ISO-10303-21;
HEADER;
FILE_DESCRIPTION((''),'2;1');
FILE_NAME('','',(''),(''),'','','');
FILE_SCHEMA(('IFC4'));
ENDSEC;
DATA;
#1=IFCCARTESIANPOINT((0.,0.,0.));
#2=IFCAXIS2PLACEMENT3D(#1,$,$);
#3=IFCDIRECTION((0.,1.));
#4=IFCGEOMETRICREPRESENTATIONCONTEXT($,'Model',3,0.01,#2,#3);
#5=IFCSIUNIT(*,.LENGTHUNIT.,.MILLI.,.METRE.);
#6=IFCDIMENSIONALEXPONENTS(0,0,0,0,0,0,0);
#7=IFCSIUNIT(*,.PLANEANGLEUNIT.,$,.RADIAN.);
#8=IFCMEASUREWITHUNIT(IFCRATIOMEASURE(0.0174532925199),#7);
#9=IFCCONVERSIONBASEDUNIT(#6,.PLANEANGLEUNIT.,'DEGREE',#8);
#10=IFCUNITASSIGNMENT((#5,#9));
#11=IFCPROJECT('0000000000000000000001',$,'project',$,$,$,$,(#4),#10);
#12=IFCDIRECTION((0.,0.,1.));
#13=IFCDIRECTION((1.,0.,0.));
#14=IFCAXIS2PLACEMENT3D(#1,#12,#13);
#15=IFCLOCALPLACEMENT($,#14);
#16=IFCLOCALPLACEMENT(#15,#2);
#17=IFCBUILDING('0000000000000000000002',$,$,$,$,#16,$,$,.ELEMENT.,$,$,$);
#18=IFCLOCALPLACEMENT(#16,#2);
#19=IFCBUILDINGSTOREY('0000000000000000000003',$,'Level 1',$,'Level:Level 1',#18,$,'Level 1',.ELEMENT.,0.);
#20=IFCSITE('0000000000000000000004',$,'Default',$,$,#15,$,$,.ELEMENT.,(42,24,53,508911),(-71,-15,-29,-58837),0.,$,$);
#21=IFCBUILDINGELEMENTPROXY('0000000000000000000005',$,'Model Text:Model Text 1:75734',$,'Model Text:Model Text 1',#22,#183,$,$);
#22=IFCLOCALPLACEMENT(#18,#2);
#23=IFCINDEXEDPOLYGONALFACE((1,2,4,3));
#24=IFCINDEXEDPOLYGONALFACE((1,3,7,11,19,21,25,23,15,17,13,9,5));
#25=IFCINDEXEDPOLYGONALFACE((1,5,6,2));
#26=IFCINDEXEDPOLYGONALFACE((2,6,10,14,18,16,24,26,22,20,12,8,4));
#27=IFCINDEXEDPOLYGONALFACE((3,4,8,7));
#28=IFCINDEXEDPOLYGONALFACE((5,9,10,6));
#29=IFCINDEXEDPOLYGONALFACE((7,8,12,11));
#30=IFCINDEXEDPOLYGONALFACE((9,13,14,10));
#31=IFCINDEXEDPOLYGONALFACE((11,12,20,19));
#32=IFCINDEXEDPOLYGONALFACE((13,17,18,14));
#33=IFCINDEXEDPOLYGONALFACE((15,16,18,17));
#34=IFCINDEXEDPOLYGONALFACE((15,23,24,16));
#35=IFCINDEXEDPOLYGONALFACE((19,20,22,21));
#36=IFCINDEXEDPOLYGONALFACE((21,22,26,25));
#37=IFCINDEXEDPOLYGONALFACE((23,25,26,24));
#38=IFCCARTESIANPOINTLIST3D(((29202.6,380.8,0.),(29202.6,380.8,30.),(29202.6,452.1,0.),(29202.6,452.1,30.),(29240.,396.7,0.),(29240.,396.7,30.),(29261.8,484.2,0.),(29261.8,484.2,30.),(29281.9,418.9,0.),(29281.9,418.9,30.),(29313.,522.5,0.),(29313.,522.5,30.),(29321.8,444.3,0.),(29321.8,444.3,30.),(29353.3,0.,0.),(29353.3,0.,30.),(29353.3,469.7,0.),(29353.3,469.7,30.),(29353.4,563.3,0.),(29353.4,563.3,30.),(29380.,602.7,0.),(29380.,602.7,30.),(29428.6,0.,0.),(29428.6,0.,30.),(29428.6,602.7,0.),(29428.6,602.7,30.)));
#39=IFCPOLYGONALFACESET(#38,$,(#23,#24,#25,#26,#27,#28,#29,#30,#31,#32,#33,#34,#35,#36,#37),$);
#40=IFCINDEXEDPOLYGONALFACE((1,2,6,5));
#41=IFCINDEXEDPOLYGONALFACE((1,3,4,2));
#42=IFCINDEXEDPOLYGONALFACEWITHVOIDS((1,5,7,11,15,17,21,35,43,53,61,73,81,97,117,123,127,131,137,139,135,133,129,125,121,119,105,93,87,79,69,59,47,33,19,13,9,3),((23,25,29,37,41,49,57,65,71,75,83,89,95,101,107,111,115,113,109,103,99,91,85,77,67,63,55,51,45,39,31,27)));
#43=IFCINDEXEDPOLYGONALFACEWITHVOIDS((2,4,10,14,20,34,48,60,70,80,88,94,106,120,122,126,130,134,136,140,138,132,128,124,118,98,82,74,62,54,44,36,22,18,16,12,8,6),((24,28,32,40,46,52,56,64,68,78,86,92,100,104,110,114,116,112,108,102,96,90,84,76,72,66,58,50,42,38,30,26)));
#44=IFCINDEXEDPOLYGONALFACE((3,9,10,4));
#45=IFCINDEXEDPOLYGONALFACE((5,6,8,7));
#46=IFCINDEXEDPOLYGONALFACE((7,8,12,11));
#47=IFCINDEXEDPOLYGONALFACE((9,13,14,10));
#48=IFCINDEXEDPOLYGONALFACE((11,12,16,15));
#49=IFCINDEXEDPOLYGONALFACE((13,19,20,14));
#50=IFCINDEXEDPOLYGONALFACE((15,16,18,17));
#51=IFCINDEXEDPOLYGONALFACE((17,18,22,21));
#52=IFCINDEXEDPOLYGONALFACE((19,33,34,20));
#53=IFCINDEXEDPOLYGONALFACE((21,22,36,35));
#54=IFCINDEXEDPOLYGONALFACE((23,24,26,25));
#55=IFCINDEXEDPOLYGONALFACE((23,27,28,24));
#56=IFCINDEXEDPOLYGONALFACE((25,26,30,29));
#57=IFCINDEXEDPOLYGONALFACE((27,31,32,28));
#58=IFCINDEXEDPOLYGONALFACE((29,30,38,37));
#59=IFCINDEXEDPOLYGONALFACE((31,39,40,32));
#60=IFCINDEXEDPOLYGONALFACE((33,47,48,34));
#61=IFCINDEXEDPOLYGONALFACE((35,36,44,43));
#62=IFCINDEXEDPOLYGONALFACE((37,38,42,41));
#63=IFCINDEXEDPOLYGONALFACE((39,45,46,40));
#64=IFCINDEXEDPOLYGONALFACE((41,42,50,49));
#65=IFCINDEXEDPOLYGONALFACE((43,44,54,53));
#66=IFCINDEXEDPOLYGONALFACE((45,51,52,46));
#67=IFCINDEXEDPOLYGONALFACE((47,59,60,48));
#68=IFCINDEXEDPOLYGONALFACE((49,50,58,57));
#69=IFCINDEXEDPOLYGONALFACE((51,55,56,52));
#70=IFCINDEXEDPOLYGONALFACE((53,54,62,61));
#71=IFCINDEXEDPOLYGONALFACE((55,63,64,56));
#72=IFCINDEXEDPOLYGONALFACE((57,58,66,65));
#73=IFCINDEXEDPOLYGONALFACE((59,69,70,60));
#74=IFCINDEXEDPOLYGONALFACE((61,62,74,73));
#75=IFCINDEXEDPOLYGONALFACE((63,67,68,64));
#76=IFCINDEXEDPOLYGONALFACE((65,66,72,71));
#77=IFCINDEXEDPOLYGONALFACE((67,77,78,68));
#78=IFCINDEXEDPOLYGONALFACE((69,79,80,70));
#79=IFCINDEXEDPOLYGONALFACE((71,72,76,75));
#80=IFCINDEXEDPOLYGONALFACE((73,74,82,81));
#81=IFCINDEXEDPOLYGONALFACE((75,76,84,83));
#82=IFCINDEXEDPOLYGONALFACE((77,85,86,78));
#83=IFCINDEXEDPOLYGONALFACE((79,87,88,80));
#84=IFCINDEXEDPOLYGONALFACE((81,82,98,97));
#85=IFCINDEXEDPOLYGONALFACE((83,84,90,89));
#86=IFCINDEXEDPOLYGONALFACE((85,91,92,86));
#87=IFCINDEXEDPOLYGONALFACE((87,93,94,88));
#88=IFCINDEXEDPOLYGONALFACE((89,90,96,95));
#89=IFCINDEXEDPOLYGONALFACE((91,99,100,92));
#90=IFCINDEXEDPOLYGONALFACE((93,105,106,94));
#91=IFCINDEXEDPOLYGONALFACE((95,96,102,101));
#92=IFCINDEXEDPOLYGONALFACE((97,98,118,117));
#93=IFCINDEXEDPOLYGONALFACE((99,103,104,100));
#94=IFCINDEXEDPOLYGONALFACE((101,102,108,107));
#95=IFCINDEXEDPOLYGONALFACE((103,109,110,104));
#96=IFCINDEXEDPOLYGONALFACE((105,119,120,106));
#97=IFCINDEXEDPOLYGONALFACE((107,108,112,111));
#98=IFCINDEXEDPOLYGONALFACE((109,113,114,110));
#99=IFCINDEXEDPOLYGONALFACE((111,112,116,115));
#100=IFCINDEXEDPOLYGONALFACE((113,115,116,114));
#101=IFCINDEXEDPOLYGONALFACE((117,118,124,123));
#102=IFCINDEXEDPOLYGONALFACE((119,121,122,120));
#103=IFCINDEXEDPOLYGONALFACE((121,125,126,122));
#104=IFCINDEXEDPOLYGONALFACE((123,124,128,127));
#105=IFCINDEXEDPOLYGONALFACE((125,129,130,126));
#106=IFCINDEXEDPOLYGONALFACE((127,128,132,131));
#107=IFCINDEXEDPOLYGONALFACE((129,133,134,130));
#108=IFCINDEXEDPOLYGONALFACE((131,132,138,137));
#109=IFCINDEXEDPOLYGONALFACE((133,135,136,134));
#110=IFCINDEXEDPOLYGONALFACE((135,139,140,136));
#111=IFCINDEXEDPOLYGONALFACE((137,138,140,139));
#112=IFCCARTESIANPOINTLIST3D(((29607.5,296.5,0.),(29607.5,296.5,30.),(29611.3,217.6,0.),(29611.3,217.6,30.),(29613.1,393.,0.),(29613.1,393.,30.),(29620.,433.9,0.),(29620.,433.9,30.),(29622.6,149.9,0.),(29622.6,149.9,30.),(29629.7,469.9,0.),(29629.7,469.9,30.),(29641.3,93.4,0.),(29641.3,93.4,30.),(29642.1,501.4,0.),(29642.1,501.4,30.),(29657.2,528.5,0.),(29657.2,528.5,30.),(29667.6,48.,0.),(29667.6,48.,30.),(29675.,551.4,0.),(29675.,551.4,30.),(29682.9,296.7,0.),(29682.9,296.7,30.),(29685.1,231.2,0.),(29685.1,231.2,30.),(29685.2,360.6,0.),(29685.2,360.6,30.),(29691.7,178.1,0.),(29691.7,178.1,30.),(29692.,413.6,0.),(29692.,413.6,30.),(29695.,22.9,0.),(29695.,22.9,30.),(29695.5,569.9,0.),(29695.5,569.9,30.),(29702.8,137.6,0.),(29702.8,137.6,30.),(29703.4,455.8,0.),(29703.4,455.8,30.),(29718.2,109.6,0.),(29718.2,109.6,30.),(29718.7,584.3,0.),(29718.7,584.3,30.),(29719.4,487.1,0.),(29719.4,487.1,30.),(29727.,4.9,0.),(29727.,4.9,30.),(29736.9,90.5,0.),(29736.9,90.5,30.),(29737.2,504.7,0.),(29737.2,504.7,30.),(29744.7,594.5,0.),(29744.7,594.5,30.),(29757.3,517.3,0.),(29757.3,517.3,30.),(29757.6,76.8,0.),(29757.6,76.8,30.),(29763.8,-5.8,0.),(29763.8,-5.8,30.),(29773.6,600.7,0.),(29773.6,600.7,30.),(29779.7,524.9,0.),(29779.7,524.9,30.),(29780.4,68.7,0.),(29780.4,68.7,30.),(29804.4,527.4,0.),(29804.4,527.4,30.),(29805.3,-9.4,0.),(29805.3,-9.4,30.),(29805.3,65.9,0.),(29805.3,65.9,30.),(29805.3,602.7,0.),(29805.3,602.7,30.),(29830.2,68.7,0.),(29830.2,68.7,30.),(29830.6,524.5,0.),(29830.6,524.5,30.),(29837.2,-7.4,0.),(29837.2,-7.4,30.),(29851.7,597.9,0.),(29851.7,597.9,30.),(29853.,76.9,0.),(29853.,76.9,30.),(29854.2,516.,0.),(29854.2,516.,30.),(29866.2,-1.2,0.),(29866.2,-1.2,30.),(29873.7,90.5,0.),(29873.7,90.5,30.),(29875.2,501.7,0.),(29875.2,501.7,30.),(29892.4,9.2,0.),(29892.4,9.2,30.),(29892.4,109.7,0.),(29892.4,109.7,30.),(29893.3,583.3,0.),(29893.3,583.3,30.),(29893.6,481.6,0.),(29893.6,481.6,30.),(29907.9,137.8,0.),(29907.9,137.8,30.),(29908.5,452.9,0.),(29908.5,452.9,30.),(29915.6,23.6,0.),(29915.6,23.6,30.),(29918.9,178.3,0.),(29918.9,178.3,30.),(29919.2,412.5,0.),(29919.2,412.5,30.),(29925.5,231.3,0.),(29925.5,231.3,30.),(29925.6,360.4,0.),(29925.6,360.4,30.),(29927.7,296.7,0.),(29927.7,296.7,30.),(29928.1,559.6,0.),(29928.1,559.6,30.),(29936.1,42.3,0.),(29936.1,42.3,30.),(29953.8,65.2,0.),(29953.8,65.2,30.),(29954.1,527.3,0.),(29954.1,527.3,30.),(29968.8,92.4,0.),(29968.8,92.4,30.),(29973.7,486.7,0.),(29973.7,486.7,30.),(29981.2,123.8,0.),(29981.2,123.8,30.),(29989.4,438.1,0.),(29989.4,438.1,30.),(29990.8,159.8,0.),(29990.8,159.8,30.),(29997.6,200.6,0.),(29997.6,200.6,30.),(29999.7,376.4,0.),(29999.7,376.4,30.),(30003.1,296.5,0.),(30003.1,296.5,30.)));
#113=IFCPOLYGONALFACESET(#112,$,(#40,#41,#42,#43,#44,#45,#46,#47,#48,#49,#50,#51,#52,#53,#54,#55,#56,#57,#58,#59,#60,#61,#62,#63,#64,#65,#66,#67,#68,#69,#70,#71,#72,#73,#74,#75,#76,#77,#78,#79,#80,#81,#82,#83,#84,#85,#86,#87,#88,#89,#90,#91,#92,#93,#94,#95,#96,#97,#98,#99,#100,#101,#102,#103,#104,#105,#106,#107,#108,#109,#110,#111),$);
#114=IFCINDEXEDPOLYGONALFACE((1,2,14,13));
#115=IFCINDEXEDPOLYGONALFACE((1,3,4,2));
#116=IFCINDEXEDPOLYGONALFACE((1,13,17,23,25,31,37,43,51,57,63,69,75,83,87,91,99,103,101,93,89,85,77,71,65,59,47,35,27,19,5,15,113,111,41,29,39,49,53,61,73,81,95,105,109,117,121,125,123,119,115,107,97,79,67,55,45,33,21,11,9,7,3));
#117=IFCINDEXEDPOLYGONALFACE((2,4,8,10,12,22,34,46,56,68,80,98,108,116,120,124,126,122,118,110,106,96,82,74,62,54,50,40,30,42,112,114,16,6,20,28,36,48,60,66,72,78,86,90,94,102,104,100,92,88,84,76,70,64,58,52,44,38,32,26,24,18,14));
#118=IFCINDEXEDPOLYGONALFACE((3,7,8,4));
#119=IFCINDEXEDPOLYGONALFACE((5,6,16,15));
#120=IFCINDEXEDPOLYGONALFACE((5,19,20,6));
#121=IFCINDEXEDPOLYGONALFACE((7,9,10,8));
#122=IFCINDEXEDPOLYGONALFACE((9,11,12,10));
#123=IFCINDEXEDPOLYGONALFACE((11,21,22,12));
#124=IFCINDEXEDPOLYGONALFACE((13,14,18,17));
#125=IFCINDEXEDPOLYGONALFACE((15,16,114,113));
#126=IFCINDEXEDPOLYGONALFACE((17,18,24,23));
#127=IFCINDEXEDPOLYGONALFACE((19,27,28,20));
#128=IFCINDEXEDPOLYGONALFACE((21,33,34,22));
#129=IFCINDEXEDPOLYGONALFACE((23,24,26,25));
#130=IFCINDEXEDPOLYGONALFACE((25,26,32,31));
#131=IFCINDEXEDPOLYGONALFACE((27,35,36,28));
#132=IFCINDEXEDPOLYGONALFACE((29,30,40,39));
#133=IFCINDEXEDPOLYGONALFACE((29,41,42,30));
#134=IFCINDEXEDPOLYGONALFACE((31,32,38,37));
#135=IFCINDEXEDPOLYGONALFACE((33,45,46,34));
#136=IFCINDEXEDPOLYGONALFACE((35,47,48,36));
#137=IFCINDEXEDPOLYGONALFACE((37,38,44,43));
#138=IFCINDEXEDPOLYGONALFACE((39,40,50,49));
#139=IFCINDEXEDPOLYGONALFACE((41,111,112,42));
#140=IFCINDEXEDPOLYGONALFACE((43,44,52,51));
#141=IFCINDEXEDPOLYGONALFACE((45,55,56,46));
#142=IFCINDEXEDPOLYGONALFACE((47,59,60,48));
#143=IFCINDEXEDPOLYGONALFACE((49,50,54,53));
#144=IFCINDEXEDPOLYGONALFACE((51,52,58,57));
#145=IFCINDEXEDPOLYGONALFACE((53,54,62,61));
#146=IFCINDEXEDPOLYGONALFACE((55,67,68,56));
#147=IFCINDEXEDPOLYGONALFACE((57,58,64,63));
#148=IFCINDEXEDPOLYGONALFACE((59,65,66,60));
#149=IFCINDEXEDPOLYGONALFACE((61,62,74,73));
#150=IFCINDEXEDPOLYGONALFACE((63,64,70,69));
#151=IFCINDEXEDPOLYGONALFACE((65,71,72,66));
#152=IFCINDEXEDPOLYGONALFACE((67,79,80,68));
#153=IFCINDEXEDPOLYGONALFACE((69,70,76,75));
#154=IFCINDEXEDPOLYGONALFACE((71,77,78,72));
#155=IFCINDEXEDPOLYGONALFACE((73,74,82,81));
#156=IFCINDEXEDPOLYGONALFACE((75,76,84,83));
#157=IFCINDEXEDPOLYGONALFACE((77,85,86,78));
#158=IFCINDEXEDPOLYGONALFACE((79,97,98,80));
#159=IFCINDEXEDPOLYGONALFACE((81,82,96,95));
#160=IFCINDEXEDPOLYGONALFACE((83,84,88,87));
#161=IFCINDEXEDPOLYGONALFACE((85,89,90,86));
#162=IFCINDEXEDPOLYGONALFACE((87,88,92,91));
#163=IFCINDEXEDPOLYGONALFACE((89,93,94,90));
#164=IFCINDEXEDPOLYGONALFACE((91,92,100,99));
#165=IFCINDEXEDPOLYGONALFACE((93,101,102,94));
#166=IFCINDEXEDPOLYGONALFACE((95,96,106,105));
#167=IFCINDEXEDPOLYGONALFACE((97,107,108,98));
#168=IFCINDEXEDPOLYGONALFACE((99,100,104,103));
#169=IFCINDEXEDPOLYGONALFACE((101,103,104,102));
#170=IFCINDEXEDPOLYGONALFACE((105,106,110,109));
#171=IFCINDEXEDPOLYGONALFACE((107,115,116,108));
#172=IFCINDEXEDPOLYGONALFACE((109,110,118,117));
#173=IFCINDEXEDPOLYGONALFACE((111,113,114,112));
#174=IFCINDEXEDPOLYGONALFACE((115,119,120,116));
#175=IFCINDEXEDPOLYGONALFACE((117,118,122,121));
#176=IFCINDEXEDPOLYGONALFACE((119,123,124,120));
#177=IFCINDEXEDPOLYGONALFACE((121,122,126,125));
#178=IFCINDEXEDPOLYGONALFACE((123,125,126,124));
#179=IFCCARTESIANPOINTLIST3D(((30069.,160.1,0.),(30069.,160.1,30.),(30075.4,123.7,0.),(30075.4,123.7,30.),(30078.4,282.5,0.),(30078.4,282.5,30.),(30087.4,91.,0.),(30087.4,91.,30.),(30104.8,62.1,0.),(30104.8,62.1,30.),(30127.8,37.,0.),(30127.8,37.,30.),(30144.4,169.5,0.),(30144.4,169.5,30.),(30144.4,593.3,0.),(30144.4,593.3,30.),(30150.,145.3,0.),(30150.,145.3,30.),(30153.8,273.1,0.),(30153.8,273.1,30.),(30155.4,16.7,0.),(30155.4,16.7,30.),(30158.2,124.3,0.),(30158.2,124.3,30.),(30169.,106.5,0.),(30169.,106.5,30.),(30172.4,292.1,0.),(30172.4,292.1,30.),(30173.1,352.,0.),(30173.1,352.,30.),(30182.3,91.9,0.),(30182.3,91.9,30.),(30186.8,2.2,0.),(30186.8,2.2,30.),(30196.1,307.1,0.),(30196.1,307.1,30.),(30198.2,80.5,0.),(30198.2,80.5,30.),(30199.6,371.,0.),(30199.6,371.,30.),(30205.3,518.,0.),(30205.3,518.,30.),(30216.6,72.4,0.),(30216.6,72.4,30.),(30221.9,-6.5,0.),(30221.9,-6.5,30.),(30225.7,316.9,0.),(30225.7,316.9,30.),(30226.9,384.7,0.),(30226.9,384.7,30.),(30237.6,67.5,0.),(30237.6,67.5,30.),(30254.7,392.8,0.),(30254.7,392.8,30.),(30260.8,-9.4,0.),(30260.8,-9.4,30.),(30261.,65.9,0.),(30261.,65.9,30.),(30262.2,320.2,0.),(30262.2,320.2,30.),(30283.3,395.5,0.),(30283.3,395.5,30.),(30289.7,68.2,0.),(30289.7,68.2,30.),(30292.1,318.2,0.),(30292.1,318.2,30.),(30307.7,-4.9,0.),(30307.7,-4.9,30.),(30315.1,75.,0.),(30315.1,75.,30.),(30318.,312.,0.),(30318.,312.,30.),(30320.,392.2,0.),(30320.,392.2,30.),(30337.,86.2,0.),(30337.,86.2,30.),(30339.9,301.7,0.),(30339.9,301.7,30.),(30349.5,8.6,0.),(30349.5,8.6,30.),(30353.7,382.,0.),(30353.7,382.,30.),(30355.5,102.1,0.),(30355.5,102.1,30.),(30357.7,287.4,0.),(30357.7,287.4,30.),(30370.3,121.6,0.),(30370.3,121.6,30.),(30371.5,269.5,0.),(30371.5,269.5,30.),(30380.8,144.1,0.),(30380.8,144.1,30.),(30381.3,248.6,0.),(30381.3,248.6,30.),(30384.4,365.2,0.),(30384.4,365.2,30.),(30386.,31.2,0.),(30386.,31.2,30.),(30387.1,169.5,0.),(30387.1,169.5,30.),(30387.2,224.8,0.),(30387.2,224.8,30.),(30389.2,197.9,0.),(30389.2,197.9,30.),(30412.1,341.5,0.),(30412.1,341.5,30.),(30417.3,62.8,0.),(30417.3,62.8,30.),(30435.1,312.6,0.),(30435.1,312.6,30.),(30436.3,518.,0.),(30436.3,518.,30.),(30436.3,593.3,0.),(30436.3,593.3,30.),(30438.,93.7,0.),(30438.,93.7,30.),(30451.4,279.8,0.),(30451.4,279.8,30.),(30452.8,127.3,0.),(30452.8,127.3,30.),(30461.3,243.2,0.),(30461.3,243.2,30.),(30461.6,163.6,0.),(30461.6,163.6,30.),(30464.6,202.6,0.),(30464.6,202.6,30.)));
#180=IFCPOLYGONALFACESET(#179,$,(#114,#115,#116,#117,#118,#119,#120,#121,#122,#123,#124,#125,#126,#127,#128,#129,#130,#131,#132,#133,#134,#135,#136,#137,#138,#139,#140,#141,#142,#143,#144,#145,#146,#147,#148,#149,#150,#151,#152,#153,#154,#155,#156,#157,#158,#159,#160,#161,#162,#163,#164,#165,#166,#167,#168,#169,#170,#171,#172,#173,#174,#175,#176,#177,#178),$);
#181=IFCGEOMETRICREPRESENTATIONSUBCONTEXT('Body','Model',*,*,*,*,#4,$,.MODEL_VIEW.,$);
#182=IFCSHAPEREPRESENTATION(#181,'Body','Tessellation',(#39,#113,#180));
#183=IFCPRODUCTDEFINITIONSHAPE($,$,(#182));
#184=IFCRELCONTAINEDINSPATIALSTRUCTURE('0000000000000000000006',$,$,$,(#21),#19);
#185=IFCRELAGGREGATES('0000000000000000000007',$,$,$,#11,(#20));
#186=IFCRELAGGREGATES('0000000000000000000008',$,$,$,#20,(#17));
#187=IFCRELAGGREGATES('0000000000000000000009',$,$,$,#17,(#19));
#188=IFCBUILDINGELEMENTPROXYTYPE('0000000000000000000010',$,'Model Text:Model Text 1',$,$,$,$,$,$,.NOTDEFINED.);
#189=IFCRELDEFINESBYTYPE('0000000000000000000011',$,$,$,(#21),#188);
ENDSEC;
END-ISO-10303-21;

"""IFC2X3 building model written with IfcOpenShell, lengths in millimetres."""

from ifc_helpers import new_model, entity, si_unit, converted_unit, direction, frame, origin, origin_with_axes, place, context, subcontext, project, spatial, polyline, outline, extrude, type_object, element, save


model = new_model("IFC2X3")

# Units and contexts
model_context = context("Model", 3, precision=0.01, world=origin(), true_north=direction((0.0, 1.0)))
body_context = subcontext(model_context, "Body", "Model", "MODEL_VIEW")
ifc_project = project(units=[si_unit("LENGTHUNIT", "METRE", prefix="MILLI"), converted_unit("PLANEANGLEUNIT", "DEGREE", entity("IfcRatioMeasure", 0.0174532925199), si_unit("PLANEANGLEUNIT", "RADIAN"), dimensions=[0, 0, 0, 0, 0, 0, 0])], contexts=[model_context])

# Site, building, storey
site_placement = place(None, origin_with_axes())
site = spatial("IfcSite", under=ifc_project, at=site_placement, Name="Default", CompositionType="ELEMENT", RefLatitude=(42, 24, 53, 508911), RefLongitude=(-71, -15, -29, -58837), RefElevation=0.0)
building_placement = place(site_placement, origin())
building = spatial("IfcBuilding", under=site, at=building_placement, CompositionType="ELEMENT")
storey_placement = place(building_placement, origin())
storey = spatial("IfcBuildingStorey", under=building, at=storey_placement, Name="Level 1", ObjectType="Level:Level 1", LongName="Level 1", CompositionType="ELEMENT", Elevation=0.0)

# Building element proxy
building_element_proxy_type_1 = type_object("IfcBuildingElementProxyType", Name="Model Text:Model Text 1", PredefinedType="NOTDEFINED")
proxy_1_placement = place(storey_placement, frame((29202.6, -9.4, 0.0)))
element("IfcBuildingElementProxy", 1, at=proxy_1_placement, inside=storey, type_object=building_element_proxy_type_1, Name="Model Text:Model Text 1:75734", ObjectType="Model Text:Model Text 1", context=body_context, shape_type="SweptSolid", body=[
    extrude(outline(polyline([(-410.6, -111.6), (192.1, -111.6), (192.1, -63.1), (152.7, -36.4), (111.9, 4.0), (73.6, 55.2), (41.4, 114.4), (-29.8, 114.4), (-13.9, 77.0), (8.3, 35.1), (33.7, -4.8), (59.1, -36.3), (-410.6, -36.3), (-410.6, -111.6)])), frame((114.4, 420.0, 0.0), z_axis=(0.0, 0.0, 1.0), x_axis=(0.0, 1.0, 0.0)), (0.0, 0.0, 1.0), 30.0),
    extrude(outline(polyline([(-10.6, -198.7), (68.3, -198.7), (136.5, -190.7), (193.9, -174.7), (240.5, -150.6), (266.9, -124.4), (286.3, -93.2), (298.8, -57.0), (304.3, -15.7), (303.8, 16.2), (299.0, 45.5), (289.9, 72.1), (276.6, 96.0), (258.9, 117.3), (236.9, 136.2), (210.4, 152.5), (179.6, 166.3), (144.1, 177.6), (103.7, 186.3), (8.2, 196.4), (-71.8, 196.7), (-134.0, 189.4), (-183.3, 176.1), (-224.7, 158.4), (-258.2, 133.9), (-283.5, 100.3), (-300.1, 59.5), (-307.1, 13.4), (-306.6, -18.4), (-301.8, -47.5), (-292.8, -74.0), (-279.6, -97.9), (-262.0, -119.2), (-240.0, -138.1), (-213.6, -154.5), (-182.8, -168.4), (-147.3, -179.8), (-106.7, -188.6), (-10.6, -198.7)]), holes=[polyline([(-7.2, -123.5), (-71.0, -118.2), (-123.6, -108.8), (-165.2, -95.4), (-195.7, -78.0), (-212.4, -59.4), (-224.1, -38.7), (-230.6, -15.9), (-231.9, 8.9), (-227.8, 35.0), (-218.1, 58.1), (-202.8, 78.4), (-182.0, 95.8), (-152.6, 109.4), (-111.7, 118.1), (-59.4, 122.0), (4.4, 121.1), (69.6, 115.8), (122.2, 106.7), (162.2, 93.7), (189.5, 77.0), (207.7, 57.4), (220.4, 36.0), (227.5, 12.8), (229.1, -12.1), (225.2, -36.8), (215.9, -59.2), (201.3, -79.3), (181.4, -97.1), (152.6, -111.2), (111.6, -120.3), (58.3, -124.4), (-7.2, -123.5)])]), frame((604.0, 304.7, 0.0), z_axis=(0.0, 0.0, 1.0), x_axis=(0.047515, -0.998871, 0.0)), (0.0, 0.0, 1.0), 30.0),
    extrude(outline(polyline([(12.1, -219.3), (49.1, -219.3), (83.4, -213.2), (114.8, -201.1), (143.5, -182.8), (168.3, -159.2), (188.1, -130.8), (202.8, -97.8), (212.4, -60.0), (216.1, -12.9), (210.0, 30.5), (194.1, 70.4), (168.4, 106.8), (141.6, 132.5), (111.1, 152.9), (76.9, 167.9), (39.0, 177.6), (-1.5, 181.4), (-39.3, 178.1), (-74.4, 167.6), (-106.9, 150.1), (-135.0, 126.9), (-157.0, 99.6), (-172.8, 68.1), (-182.5, 32.6), (-184.8, 4.0), (-181.6, -24.8), (-172.9, -54.0), (-158.8, -83.5), (-316.6, -22.9), (-276.5, 204.6), (-350.7, 217.7), (-401.4, -69.8), (-106.8, -188.8), (-84.5, -116.2), (-99.9, -94.5), (-110.6, -68.6), (-115.1, -37.8), (-112.0, -1.2), (-104.8, 27.9), (-94.2, 52.3), (-80.3, 72.0), (-63.1, 87.0), (-43.0, 97.5), (-20.8, 103.6), (3.8, 105.3), (30.5, 102.6), (58.1, 95.6), (82.1, 84.9), (102.4, 70.6), (119.1, 52.7), (131.4, 31.7), (138.7, 8.2), (141.0, -17.9), (138.2, -46.6), (132.6, -69.4), (124.1, -89.2), (112.9, -105.9), (99.0, -119.6), (82.3, -130.2), (62.9, -137.7), (40.8, -142.2), (15.9, -143.5), (12.1, -219.3)])), frame((1080.3, 219.6, 0.0), z_axis=(0.0, 0.0, 1.0), x_axis=(0.173842, -0.984774, 0.0)), (0.0, 0.0, 1.0), 30.0),
])

save(model, "model.ifc")
